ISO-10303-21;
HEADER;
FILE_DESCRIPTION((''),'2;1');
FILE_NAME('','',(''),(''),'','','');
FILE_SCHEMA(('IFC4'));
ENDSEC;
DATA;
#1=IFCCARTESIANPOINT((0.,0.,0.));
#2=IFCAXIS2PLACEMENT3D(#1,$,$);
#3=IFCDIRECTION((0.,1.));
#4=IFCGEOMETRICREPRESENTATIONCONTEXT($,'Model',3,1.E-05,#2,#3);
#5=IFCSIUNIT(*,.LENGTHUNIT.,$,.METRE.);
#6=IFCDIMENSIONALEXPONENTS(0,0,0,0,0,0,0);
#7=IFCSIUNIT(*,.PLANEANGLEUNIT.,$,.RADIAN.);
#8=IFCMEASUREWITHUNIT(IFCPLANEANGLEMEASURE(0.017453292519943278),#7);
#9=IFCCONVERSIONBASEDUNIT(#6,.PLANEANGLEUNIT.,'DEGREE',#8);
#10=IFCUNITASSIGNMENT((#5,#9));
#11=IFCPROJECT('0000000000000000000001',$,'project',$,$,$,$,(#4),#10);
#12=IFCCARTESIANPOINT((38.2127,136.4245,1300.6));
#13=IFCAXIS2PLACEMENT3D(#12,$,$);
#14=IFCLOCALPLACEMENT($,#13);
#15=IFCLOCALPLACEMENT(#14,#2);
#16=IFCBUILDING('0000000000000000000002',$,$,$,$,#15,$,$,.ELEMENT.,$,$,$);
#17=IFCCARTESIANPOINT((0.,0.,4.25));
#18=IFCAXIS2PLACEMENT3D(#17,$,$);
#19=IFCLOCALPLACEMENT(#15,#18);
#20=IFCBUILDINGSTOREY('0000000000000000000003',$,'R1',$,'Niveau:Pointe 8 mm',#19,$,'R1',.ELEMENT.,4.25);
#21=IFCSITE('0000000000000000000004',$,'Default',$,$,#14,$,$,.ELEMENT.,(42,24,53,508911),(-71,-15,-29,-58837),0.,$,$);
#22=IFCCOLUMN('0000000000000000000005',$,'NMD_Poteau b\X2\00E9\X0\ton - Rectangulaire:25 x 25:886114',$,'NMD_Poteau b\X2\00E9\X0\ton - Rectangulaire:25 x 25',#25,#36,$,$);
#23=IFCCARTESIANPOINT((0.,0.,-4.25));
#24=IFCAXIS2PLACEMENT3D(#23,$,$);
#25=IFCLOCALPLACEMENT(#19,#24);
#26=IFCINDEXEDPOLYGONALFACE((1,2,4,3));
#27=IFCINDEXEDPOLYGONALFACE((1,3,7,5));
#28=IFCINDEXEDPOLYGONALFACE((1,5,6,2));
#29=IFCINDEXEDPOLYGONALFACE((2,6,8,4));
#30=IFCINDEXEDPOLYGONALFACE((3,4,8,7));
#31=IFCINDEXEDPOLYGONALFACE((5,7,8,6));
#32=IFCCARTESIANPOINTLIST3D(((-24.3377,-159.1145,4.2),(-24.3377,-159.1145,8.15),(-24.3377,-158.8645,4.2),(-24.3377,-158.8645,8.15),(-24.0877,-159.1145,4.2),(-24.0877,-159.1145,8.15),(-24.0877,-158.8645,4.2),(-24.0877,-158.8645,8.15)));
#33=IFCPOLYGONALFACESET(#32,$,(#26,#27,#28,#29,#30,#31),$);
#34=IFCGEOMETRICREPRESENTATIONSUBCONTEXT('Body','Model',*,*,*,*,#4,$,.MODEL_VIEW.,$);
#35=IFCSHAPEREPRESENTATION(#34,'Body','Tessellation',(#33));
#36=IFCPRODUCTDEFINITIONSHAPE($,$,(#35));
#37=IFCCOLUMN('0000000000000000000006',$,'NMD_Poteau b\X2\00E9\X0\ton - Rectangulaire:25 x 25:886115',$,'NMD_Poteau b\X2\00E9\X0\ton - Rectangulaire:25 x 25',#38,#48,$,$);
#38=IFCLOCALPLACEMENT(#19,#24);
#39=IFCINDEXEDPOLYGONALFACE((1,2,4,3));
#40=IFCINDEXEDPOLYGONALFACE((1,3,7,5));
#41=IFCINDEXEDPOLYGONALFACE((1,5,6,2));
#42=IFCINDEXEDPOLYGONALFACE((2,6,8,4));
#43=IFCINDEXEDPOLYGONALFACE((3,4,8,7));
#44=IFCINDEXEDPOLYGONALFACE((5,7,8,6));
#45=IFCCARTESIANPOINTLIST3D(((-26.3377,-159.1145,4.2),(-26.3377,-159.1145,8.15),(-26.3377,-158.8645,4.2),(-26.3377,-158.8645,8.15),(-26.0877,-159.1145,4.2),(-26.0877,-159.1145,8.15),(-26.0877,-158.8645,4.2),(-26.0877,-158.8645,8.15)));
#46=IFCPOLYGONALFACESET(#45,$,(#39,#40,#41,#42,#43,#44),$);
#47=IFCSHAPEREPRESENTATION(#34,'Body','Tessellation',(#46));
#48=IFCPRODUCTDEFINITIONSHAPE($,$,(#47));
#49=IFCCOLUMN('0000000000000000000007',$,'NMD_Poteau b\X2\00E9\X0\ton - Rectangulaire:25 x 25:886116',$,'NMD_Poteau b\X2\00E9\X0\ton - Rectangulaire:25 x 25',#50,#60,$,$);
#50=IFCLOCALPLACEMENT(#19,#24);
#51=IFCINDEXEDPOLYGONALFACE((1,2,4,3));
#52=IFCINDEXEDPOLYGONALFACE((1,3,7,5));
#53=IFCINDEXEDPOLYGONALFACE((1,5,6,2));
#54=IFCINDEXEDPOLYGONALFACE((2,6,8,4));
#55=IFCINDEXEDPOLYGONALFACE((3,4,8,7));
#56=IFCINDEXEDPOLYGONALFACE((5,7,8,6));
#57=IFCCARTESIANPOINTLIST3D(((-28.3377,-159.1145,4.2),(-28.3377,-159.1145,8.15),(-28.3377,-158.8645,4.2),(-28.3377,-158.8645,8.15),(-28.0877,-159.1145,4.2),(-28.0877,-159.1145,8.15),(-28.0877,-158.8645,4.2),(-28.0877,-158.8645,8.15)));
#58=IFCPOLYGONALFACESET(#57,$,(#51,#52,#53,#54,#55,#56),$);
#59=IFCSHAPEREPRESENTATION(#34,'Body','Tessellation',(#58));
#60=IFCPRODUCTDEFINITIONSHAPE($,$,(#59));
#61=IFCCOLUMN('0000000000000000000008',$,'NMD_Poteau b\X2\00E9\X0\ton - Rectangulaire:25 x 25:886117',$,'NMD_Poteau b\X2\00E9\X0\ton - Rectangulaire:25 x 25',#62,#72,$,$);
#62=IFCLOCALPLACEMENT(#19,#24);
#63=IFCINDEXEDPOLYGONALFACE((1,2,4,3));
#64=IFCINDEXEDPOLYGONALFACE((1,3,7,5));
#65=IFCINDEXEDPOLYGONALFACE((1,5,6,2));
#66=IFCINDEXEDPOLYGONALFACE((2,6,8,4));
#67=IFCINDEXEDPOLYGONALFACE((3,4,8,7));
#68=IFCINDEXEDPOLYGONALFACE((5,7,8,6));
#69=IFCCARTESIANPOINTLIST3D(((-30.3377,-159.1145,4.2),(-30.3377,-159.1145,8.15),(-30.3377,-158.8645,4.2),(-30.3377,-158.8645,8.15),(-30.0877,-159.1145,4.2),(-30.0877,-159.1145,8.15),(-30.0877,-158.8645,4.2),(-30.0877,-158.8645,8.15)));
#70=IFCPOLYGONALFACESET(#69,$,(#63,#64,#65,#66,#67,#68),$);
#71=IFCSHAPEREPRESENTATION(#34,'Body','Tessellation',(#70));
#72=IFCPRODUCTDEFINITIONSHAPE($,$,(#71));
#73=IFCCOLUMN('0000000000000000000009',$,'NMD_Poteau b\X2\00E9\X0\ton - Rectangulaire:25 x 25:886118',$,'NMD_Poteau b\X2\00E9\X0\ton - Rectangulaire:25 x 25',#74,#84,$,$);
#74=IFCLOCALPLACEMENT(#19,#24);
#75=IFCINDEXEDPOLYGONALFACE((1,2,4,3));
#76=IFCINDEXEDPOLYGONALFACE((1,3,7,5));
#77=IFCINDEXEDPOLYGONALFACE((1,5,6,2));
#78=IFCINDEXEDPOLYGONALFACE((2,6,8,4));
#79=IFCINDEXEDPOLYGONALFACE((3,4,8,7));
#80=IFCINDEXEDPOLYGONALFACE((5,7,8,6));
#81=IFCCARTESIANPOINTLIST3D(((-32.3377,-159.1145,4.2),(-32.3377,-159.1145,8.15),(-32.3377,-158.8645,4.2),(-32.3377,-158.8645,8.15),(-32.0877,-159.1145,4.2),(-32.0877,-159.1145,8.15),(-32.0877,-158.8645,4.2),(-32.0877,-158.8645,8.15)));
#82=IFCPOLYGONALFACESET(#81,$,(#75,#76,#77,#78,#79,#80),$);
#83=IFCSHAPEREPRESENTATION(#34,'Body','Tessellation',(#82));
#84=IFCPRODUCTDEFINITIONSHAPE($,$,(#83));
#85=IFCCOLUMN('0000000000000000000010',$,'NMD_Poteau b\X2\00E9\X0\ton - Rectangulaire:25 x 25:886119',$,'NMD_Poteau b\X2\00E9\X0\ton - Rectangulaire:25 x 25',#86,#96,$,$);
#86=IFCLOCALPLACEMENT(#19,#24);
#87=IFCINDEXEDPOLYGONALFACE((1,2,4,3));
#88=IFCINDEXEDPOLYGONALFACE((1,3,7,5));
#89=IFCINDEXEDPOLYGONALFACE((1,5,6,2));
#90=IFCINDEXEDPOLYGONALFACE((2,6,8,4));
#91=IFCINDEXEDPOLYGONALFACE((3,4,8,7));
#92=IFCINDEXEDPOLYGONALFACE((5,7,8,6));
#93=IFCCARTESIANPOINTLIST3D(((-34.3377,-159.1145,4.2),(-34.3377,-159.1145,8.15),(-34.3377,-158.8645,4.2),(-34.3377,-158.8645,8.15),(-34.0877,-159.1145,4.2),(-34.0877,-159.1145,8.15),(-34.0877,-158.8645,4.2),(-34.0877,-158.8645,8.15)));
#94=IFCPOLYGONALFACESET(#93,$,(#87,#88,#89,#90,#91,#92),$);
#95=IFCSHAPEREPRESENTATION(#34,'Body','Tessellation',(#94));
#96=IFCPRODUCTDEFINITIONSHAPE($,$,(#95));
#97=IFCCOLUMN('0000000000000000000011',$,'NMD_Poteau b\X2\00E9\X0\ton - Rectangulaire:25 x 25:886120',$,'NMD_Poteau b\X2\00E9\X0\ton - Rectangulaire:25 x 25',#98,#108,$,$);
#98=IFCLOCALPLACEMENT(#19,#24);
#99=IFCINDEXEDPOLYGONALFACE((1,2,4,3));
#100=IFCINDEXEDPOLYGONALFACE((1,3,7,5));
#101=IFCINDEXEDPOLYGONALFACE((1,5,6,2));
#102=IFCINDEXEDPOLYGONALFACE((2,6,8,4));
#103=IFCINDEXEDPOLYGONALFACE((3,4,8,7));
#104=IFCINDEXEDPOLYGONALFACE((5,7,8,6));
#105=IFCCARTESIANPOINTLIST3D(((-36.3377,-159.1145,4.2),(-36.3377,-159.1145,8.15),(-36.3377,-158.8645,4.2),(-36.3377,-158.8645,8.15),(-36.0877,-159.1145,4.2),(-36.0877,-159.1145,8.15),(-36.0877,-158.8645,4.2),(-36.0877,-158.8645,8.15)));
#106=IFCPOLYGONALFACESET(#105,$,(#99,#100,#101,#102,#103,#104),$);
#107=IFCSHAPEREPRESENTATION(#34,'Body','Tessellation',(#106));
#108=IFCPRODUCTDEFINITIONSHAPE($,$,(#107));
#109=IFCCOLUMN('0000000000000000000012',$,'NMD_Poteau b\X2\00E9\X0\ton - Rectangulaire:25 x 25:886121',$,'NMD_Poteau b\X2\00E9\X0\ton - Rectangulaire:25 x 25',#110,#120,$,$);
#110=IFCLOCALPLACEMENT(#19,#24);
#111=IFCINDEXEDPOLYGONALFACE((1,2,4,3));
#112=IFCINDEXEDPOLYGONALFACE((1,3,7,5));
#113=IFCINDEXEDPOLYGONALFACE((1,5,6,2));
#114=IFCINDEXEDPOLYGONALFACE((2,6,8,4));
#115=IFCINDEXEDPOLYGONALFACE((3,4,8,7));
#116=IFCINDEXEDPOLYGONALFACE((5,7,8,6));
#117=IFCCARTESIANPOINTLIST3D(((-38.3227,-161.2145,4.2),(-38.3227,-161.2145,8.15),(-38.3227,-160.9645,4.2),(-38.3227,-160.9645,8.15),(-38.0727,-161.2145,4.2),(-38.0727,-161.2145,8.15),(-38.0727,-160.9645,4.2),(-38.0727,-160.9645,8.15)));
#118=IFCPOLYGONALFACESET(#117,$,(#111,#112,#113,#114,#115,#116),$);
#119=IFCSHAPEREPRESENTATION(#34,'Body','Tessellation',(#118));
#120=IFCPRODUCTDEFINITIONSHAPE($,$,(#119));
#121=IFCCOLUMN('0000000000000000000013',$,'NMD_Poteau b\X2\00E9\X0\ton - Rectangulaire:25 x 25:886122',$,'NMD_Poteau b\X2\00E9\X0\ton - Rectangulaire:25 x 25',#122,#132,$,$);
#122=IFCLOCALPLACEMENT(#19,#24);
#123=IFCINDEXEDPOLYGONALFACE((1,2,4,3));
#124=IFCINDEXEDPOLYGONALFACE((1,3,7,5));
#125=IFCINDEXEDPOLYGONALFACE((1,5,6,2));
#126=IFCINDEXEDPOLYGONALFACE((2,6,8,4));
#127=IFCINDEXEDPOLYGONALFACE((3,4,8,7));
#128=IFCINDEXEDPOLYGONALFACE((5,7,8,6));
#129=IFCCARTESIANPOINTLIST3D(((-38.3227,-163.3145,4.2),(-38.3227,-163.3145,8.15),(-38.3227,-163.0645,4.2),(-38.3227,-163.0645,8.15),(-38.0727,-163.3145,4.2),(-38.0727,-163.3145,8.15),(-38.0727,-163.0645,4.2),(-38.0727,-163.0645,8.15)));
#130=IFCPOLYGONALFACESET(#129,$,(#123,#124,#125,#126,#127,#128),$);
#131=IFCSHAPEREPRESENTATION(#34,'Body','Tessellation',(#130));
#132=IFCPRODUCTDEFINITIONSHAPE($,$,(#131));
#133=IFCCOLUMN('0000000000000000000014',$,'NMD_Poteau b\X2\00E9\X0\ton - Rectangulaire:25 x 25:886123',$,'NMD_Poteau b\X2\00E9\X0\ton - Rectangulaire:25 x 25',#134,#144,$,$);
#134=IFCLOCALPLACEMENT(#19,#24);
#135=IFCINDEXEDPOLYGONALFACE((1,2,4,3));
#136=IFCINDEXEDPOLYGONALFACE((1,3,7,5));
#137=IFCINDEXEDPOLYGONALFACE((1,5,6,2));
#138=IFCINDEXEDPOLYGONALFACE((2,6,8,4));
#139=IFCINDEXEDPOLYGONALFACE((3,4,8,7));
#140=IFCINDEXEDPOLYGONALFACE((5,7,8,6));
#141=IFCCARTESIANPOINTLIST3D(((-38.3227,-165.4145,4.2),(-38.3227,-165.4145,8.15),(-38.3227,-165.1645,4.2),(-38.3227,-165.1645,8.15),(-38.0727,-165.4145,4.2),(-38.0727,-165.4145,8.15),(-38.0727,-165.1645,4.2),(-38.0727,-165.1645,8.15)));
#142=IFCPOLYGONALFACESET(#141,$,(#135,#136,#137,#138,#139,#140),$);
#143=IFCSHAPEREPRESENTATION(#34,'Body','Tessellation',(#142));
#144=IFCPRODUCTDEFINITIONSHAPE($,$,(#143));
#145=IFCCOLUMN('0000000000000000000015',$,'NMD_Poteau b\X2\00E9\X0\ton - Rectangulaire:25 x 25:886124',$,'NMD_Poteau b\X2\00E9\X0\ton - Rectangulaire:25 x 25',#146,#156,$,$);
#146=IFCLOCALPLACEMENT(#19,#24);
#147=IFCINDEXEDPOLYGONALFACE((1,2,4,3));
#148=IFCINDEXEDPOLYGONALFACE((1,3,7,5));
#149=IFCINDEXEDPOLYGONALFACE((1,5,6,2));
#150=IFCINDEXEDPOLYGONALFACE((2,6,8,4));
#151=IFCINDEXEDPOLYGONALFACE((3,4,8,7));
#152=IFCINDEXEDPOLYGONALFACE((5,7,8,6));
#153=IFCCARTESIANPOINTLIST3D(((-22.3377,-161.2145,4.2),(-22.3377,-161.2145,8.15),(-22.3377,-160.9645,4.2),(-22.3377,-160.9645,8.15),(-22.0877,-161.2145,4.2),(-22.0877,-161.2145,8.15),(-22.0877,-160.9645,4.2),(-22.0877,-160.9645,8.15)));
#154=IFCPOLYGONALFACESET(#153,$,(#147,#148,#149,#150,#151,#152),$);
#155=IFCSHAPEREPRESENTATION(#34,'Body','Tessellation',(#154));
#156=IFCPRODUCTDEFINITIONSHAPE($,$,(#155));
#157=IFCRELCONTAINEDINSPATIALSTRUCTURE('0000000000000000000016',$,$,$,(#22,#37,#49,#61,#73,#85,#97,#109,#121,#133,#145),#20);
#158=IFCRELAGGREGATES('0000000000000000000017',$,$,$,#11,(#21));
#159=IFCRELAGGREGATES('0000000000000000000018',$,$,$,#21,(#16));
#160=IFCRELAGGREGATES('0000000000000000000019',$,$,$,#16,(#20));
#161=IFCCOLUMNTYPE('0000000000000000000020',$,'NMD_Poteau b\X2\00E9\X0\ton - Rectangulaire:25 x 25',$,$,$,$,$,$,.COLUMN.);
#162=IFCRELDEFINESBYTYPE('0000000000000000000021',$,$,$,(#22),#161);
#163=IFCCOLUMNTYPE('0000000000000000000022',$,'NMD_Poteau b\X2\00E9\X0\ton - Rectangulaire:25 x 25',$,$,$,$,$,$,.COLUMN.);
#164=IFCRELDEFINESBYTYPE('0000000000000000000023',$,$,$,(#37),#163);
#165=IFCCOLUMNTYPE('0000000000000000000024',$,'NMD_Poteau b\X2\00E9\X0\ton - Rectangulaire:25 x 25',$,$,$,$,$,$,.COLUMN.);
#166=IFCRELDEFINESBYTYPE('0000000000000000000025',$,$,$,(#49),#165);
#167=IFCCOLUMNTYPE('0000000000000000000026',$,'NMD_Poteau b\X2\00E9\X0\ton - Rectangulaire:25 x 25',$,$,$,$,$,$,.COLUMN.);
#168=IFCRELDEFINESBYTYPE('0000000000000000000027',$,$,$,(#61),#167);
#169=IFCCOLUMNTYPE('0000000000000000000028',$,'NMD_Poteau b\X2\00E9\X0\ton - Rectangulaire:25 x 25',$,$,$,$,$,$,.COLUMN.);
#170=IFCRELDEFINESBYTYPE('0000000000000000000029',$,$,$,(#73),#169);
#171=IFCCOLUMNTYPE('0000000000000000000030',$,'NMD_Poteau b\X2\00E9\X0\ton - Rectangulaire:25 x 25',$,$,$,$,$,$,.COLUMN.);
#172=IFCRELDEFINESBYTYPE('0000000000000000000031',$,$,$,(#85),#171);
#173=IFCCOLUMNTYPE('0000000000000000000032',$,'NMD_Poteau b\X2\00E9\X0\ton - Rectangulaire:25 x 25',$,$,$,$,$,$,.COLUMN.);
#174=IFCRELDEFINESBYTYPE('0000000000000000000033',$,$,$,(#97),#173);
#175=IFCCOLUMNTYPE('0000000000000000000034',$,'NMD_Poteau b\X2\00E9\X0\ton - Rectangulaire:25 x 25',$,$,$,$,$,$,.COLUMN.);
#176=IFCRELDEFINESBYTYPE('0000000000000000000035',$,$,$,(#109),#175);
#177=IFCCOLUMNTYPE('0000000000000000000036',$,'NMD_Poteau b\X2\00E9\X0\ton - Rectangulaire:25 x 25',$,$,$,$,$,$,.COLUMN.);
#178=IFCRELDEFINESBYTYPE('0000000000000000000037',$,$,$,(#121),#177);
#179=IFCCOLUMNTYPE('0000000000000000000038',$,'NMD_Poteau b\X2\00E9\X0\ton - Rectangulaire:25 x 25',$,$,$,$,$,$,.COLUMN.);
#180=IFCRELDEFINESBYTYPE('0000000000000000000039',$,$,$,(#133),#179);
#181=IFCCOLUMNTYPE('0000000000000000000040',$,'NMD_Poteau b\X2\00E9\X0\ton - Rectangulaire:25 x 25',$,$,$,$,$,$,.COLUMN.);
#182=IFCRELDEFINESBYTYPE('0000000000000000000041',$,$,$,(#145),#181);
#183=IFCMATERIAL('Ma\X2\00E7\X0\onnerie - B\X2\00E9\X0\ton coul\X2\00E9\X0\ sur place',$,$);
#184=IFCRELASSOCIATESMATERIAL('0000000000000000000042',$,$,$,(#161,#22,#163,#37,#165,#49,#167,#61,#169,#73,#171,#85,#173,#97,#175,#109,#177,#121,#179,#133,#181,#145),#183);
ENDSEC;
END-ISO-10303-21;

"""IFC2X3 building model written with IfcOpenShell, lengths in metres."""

from ifc_helpers import new_model, entity, si_unit, converted_unit, direction, frame, frame_2d, origin, place, context, subcontext, project, spatial, rectangle, extrude, source, transform, mapped, material, type_object, type_shapes, element, save


model = new_model("IFC2X3")

# Units and contexts
model_context = context("Model", 3, precision=1e-05, world=origin(), true_north=direction((0.0, 1.0)))
body_context = subcontext(model_context, "Body", "Model", "MODEL_VIEW")
ifc_project = project(units=[si_unit("LENGTHUNIT", "METRE"), converted_unit("PLANEANGLEUNIT", "DEGREE", entity("IfcPlaneAngleMeasure", 0.017453292519943278), si_unit("PLANEANGLEUNIT", "RADIAN"), dimensions=[0, 0, 0, 0, 0, 0, 0])], contexts=[model_context])

# Site, building, storey
site_placement = place(None, frame((38.2127, 136.4245, 1300.6)))
site = spatial("IfcSite", under=ifc_project, at=site_placement, Name="Default", CompositionType="ELEMENT", RefLatitude=(42, 24, 53, 508911), RefLongitude=(-71, -15, -29, -58837), RefElevation=0.0)
building_placement = place(site_placement, origin())
building = spatial("IfcBuilding", under=site, at=building_placement, CompositionType="ELEMENT")
storey_placement = place(building_placement, frame((0.0, 0.0, 4.25)))
storey = spatial("IfcBuildingStorey", under=building, at=storey_placement, Name="R1", ObjectType="Niveau:Pointe 8 mm", LongName="R1", CompositionType="ELEMENT", Elevation=4.25)

# Columns
ifc_material = material(Name="Maçonnerie - Béton coulé sur place")
column_type_1 = type_object("IfcColumnType", Name="NMD_Poteau béton - Rectangulaire:25 x 25", PredefinedType="COLUMN", material=ifc_material)
shared_shape_1 = source(origin(), body_context, "Body", "SweptSolid", [
    extrude(rectangle(XDim=0.25, YDim=0.25, at=frame_2d((0.0, 0.0), x_axis=(1.0, 0.0))), frame((-24.2127, -158.9895, 4.2), z_axis=(0.0, 0.0, 1.0), x_axis=(-1.0, 0.0, 0.0)), (0.0, 0.0, 1.0), 3.95),
])
type_shapes(column_type_1, [shared_shape_1])
column_1_placement = place(storey_placement, frame((0.0, 0.0, -4.25)))
element("IfcColumn", 1, at=column_1_placement, inside=storey, type_object=column_type_1, material=ifc_material, Name="NMD_Poteau béton - Rectangulaire:25 x 25:886114", ObjectType="NMD_Poteau béton - Rectangulaire:25 x 25", context=body_context, shape_type="MappedRepresentation", body=[
    mapped(shared_shape_1, transform((0.0, 0.0, 0.0), scale=1.0)),
])
column_type_2 = type_object("IfcColumnType", Name="NMD_Poteau béton - Rectangulaire:25 x 25", PredefinedType="COLUMN", material=ifc_material)
shared_shape_2 = source(origin(), body_context, "Body", "SweptSolid", [
    extrude(rectangle(XDim=0.25, YDim=0.25, at=frame_2d((0.0, 0.0), x_axis=(1.0, 0.0))), frame((-26.2127, -158.9895, 4.2), z_axis=(0.0, 0.0, 1.0), x_axis=(-1.0, 0.0, 0.0)), (0.0, 0.0, 1.0), 3.95),
])
type_shapes(column_type_2, [shared_shape_2])
column_2_placement = place(storey_placement, frame((0.0, 0.0, -4.25)))
element("IfcColumn", 2, at=column_2_placement, inside=storey, type_object=column_type_2, material=ifc_material, Name="NMD_Poteau béton - Rectangulaire:25 x 25:886115", ObjectType="NMD_Poteau béton - Rectangulaire:25 x 25", context=body_context, shape_type="MappedRepresentation", body=[
    mapped(shared_shape_2, transform((0.0, 0.0, 0.0), scale=1.0)),
])
column_type_3 = type_object("IfcColumnType", Name="NMD_Poteau béton - Rectangulaire:25 x 25", PredefinedType="COLUMN", material=ifc_material)
shared_shape_3 = source(origin(), body_context, "Body", "SweptSolid", [
    extrude(rectangle(XDim=0.25, YDim=0.25, at=frame_2d((0.0, 0.0), x_axis=(1.0, 0.0))), frame((-28.2127, -158.9895, 4.2), z_axis=(0.0, 0.0, 1.0), x_axis=(-1.0, 0.0, 0.0)), (0.0, 0.0, 1.0), 3.95),
])
type_shapes(column_type_3, [shared_shape_3])
column_3_placement = place(storey_placement, frame((0.0, 0.0, -4.25)))
element("IfcColumn", 3, at=column_3_placement, inside=storey, type_object=column_type_3, material=ifc_material, Name="NMD_Poteau béton - Rectangulaire:25 x 25:886116", ObjectType="NMD_Poteau béton - Rectangulaire:25 x 25", context=body_context, shape_type="MappedRepresentation", body=[
    mapped(shared_shape_3, transform((0.0, 0.0, 0.0), scale=1.0)),
])
column_type_4 = type_object("IfcColumnType", Name="NMD_Poteau béton - Rectangulaire:25 x 25", PredefinedType="COLUMN", material=ifc_material)
shared_shape_4 = source(origin(), body_context, "Body", "SweptSolid", [
    extrude(rectangle(XDim=0.25, YDim=0.25, at=frame_2d((0.0, 0.0), x_axis=(1.0, 0.0))), frame((-30.2127, -158.9895, 4.2), z_axis=(0.0, 0.0, 1.0), x_axis=(-1.0, 0.0, 0.0)), (0.0, 0.0, 1.0), 3.95),
])
type_shapes(column_type_4, [shared_shape_4])
column_4_placement = place(storey_placement, frame((0.0, 0.0, -4.25)))
element("IfcColumn", 4, at=column_4_placement, inside=storey, type_object=column_type_4, material=ifc_material, Name="NMD_Poteau béton - Rectangulaire:25 x 25:886117", ObjectType="NMD_Poteau béton - Rectangulaire:25 x 25", context=body_context, shape_type="MappedRepresentation", body=[
    mapped(shared_shape_4, transform((0.0, 0.0, 0.0), scale=1.0)),
])
column_type_5 = type_object("IfcColumnType", Name="NMD_Poteau béton - Rectangulaire:25 x 25", PredefinedType="COLUMN", material=ifc_material)
shared_shape_5 = source(origin(), body_context, "Body", "SweptSolid", [
    extrude(rectangle(XDim=0.25, YDim=0.25, at=frame_2d((0.0, 0.0), x_axis=(1.0, 0.0))), frame((-32.2127, -158.9895, 4.2), z_axis=(0.0, 0.0, 1.0), x_axis=(-1.0, 0.0, 0.0)), (0.0, 0.0, 1.0), 3.95),
])
type_shapes(column_type_5, [shared_shape_5])
column_5_placement = place(storey_placement, frame((0.0, 0.0, -4.25)))
element("IfcColumn", 5, at=column_5_placement, inside=storey, type_object=column_type_5, material=ifc_material, Name="NMD_Poteau béton - Rectangulaire:25 x 25:886118", ObjectType="NMD_Poteau béton - Rectangulaire:25 x 25", context=body_context, shape_type="MappedRepresentation", body=[
    mapped(shared_shape_5, transform((0.0, 0.0, 0.0), scale=1.0)),
])
column_type_6 = type_object("IfcColumnType", Name="NMD_Poteau béton - Rectangulaire:25 x 25", PredefinedType="COLUMN", material=ifc_material)
shared_shape_6 = source(origin(), body_context, "Body", "SweptSolid", [
    extrude(rectangle(XDim=0.25, YDim=0.25, at=frame_2d((0.0, 0.0), x_axis=(1.0, 0.0))), frame((-34.2127, -158.9895, 4.2), z_axis=(0.0, 0.0, 1.0), x_axis=(-1.0, 0.0, 0.0)), (0.0, 0.0, 1.0), 3.95),
])
type_shapes(column_type_6, [shared_shape_6])
column_6_placement = place(storey_placement, frame((0.0, 0.0, -4.25)))
element("IfcColumn", 6, at=column_6_placement, inside=storey, type_object=column_type_6, material=ifc_material, Name="NMD_Poteau béton - Rectangulaire:25 x 25:886119", ObjectType="NMD_Poteau béton - Rectangulaire:25 x 25", context=body_context, shape_type="MappedRepresentation", body=[
    mapped(shared_shape_6, transform((0.0, 0.0, 0.0), scale=1.0)),
])
column_type_7 = type_object("IfcColumnType", Name="NMD_Poteau béton - Rectangulaire:25 x 25", PredefinedType="COLUMN", material=ifc_material)
shared_shape_7 = source(origin(), body_context, "Body", "SweptSolid", [
    extrude(rectangle(XDim=0.25, YDim=0.25, at=frame_2d((0.0, 0.0), x_axis=(1.0, 0.0))), frame((-36.2127, -158.9895, 4.2), z_axis=(0.0, 0.0, 1.0), x_axis=(-1.0, 0.0, 0.0)), (0.0, 0.0, 1.0), 3.95),
])
type_shapes(column_type_7, [shared_shape_7])
column_7_placement = place(storey_placement, frame((0.0, 0.0, -4.25)))
element("IfcColumn", 7, at=column_7_placement, inside=storey, type_object=column_type_7, material=ifc_material, Name="NMD_Poteau béton - Rectangulaire:25 x 25:886120", ObjectType="NMD_Poteau béton - Rectangulaire:25 x 25", context=body_context, shape_type="MappedRepresentation", body=[
    mapped(shared_shape_7, transform((0.0, 0.0, 0.0), scale=1.0)),
])
column_type_8 = type_object("IfcColumnType", Name="NMD_Poteau béton - Rectangulaire:25 x 25", PredefinedType="COLUMN", material=ifc_material)
shared_shape_8 = source(origin(), body_context, "Body", "SweptSolid", [
    extrude(rectangle(XDim=0.25, YDim=0.25, at=frame_2d((0.0, 0.0), x_axis=(1.0, 0.0))), frame((-38.1977, -161.0895, 4.2), z_axis=(0.0, 0.0, 1.0), x_axis=(0.0, 1.0, 0.0)), (0.0, 0.0, 1.0), 3.95),
])
type_shapes(column_type_8, [shared_shape_8])
column_8_placement = place(storey_placement, frame((0.0, 0.0, -4.25)))
element("IfcColumn", 8, at=column_8_placement, inside=storey, type_object=column_type_8, material=ifc_material, Name="NMD_Poteau béton - Rectangulaire:25 x 25:886121", ObjectType="NMD_Poteau béton - Rectangulaire:25 x 25", context=body_context, shape_type="MappedRepresentation", body=[
    mapped(shared_shape_8, transform((0.0, 0.0, 0.0), scale=1.0)),
])
column_type_9 = type_object("IfcColumnType", Name="NMD_Poteau béton - Rectangulaire:25 x 25", PredefinedType="COLUMN", material=ifc_material)
shared_shape_9 = source(origin(), body_context, "Body", "SweptSolid", [
    extrude(rectangle(XDim=0.25, YDim=0.25, at=frame_2d((0.0, 0.0), x_axis=(1.0, 0.0))), frame((-38.1977, -163.1895, 4.2), z_axis=(0.0, 0.0, 1.0), x_axis=(0.0, 1.0, 0.0)), (0.0, 0.0, 1.0), 3.95),
])
type_shapes(column_type_9, [shared_shape_9])
column_9_placement = place(storey_placement, frame((0.0, 0.0, -4.25)))
element("IfcColumn", 9, at=column_9_placement, inside=storey, type_object=column_type_9, material=ifc_material, Name="NMD_Poteau béton - Rectangulaire:25 x 25:886122", ObjectType="NMD_Poteau béton - Rectangulaire:25 x 25", context=body_context, shape_type="MappedRepresentation", body=[
    mapped(shared_shape_9, transform((0.0, 0.0, 0.0), scale=1.0)),
])
column_type_10 = type_object("IfcColumnType", Name="NMD_Poteau béton - Rectangulaire:25 x 25", PredefinedType="COLUMN", material=ifc_material)
shared_shape_10 = source(origin(), body_context, "Body", "SweptSolid", [
    extrude(rectangle(XDim=0.25, YDim=0.25, at=frame_2d((0.0, 0.0), x_axis=(1.0, 0.0))), frame((-38.1977, -165.2895, 4.2), z_axis=(0.0, 0.0, 1.0), x_axis=(0.0, 1.0, 0.0)), (0.0, 0.0, 1.0), 3.95),
])
type_shapes(column_type_10, [shared_shape_10])
column_10_placement = place(storey_placement, frame((0.0, 0.0, -4.25)))
element("IfcColumn", 10, at=column_10_placement, inside=storey, type_object=column_type_10, material=ifc_material, Name="NMD_Poteau béton - Rectangulaire:25 x 25:886123", ObjectType="NMD_Poteau béton - Rectangulaire:25 x 25", context=body_context, shape_type="MappedRepresentation", body=[
    mapped(shared_shape_10, transform((0.0, 0.0, 0.0), scale=1.0)),
])
column_type_11 = type_object("IfcColumnType", Name="NMD_Poteau béton - Rectangulaire:25 x 25", PredefinedType="COLUMN", material=ifc_material)
shared_shape_11 = source(origin(), body_context, "Body", "SweptSolid", [
    extrude(rectangle(XDim=0.25, YDim=0.25, at=frame_2d((0.0, 0.0), x_axis=(1.0, 0.0))), frame((-22.2127, -161.0895, 4.2), z_axis=(0.0, 0.0, 1.0), x_axis=(0.0, 1.0, 0.0)), (0.0, 0.0, 1.0), 3.95),
])
type_shapes(column_type_11, [shared_shape_11])
column_11_placement = place(storey_placement, frame((0.0, 0.0, -4.25)))
element("IfcColumn", 11, at=column_11_placement, inside=storey, type_object=column_type_11, material=ifc_material, Name="NMD_Poteau béton - Rectangulaire:25 x 25:886124", ObjectType="NMD_Poteau béton - Rectangulaire:25 x 25", context=body_context, shape_type="MappedRepresentation", body=[
    mapped(shared_shape_11, transform((0.0, 0.0, 0.0), scale=1.0)),
])

save(model, "model.ifc")
